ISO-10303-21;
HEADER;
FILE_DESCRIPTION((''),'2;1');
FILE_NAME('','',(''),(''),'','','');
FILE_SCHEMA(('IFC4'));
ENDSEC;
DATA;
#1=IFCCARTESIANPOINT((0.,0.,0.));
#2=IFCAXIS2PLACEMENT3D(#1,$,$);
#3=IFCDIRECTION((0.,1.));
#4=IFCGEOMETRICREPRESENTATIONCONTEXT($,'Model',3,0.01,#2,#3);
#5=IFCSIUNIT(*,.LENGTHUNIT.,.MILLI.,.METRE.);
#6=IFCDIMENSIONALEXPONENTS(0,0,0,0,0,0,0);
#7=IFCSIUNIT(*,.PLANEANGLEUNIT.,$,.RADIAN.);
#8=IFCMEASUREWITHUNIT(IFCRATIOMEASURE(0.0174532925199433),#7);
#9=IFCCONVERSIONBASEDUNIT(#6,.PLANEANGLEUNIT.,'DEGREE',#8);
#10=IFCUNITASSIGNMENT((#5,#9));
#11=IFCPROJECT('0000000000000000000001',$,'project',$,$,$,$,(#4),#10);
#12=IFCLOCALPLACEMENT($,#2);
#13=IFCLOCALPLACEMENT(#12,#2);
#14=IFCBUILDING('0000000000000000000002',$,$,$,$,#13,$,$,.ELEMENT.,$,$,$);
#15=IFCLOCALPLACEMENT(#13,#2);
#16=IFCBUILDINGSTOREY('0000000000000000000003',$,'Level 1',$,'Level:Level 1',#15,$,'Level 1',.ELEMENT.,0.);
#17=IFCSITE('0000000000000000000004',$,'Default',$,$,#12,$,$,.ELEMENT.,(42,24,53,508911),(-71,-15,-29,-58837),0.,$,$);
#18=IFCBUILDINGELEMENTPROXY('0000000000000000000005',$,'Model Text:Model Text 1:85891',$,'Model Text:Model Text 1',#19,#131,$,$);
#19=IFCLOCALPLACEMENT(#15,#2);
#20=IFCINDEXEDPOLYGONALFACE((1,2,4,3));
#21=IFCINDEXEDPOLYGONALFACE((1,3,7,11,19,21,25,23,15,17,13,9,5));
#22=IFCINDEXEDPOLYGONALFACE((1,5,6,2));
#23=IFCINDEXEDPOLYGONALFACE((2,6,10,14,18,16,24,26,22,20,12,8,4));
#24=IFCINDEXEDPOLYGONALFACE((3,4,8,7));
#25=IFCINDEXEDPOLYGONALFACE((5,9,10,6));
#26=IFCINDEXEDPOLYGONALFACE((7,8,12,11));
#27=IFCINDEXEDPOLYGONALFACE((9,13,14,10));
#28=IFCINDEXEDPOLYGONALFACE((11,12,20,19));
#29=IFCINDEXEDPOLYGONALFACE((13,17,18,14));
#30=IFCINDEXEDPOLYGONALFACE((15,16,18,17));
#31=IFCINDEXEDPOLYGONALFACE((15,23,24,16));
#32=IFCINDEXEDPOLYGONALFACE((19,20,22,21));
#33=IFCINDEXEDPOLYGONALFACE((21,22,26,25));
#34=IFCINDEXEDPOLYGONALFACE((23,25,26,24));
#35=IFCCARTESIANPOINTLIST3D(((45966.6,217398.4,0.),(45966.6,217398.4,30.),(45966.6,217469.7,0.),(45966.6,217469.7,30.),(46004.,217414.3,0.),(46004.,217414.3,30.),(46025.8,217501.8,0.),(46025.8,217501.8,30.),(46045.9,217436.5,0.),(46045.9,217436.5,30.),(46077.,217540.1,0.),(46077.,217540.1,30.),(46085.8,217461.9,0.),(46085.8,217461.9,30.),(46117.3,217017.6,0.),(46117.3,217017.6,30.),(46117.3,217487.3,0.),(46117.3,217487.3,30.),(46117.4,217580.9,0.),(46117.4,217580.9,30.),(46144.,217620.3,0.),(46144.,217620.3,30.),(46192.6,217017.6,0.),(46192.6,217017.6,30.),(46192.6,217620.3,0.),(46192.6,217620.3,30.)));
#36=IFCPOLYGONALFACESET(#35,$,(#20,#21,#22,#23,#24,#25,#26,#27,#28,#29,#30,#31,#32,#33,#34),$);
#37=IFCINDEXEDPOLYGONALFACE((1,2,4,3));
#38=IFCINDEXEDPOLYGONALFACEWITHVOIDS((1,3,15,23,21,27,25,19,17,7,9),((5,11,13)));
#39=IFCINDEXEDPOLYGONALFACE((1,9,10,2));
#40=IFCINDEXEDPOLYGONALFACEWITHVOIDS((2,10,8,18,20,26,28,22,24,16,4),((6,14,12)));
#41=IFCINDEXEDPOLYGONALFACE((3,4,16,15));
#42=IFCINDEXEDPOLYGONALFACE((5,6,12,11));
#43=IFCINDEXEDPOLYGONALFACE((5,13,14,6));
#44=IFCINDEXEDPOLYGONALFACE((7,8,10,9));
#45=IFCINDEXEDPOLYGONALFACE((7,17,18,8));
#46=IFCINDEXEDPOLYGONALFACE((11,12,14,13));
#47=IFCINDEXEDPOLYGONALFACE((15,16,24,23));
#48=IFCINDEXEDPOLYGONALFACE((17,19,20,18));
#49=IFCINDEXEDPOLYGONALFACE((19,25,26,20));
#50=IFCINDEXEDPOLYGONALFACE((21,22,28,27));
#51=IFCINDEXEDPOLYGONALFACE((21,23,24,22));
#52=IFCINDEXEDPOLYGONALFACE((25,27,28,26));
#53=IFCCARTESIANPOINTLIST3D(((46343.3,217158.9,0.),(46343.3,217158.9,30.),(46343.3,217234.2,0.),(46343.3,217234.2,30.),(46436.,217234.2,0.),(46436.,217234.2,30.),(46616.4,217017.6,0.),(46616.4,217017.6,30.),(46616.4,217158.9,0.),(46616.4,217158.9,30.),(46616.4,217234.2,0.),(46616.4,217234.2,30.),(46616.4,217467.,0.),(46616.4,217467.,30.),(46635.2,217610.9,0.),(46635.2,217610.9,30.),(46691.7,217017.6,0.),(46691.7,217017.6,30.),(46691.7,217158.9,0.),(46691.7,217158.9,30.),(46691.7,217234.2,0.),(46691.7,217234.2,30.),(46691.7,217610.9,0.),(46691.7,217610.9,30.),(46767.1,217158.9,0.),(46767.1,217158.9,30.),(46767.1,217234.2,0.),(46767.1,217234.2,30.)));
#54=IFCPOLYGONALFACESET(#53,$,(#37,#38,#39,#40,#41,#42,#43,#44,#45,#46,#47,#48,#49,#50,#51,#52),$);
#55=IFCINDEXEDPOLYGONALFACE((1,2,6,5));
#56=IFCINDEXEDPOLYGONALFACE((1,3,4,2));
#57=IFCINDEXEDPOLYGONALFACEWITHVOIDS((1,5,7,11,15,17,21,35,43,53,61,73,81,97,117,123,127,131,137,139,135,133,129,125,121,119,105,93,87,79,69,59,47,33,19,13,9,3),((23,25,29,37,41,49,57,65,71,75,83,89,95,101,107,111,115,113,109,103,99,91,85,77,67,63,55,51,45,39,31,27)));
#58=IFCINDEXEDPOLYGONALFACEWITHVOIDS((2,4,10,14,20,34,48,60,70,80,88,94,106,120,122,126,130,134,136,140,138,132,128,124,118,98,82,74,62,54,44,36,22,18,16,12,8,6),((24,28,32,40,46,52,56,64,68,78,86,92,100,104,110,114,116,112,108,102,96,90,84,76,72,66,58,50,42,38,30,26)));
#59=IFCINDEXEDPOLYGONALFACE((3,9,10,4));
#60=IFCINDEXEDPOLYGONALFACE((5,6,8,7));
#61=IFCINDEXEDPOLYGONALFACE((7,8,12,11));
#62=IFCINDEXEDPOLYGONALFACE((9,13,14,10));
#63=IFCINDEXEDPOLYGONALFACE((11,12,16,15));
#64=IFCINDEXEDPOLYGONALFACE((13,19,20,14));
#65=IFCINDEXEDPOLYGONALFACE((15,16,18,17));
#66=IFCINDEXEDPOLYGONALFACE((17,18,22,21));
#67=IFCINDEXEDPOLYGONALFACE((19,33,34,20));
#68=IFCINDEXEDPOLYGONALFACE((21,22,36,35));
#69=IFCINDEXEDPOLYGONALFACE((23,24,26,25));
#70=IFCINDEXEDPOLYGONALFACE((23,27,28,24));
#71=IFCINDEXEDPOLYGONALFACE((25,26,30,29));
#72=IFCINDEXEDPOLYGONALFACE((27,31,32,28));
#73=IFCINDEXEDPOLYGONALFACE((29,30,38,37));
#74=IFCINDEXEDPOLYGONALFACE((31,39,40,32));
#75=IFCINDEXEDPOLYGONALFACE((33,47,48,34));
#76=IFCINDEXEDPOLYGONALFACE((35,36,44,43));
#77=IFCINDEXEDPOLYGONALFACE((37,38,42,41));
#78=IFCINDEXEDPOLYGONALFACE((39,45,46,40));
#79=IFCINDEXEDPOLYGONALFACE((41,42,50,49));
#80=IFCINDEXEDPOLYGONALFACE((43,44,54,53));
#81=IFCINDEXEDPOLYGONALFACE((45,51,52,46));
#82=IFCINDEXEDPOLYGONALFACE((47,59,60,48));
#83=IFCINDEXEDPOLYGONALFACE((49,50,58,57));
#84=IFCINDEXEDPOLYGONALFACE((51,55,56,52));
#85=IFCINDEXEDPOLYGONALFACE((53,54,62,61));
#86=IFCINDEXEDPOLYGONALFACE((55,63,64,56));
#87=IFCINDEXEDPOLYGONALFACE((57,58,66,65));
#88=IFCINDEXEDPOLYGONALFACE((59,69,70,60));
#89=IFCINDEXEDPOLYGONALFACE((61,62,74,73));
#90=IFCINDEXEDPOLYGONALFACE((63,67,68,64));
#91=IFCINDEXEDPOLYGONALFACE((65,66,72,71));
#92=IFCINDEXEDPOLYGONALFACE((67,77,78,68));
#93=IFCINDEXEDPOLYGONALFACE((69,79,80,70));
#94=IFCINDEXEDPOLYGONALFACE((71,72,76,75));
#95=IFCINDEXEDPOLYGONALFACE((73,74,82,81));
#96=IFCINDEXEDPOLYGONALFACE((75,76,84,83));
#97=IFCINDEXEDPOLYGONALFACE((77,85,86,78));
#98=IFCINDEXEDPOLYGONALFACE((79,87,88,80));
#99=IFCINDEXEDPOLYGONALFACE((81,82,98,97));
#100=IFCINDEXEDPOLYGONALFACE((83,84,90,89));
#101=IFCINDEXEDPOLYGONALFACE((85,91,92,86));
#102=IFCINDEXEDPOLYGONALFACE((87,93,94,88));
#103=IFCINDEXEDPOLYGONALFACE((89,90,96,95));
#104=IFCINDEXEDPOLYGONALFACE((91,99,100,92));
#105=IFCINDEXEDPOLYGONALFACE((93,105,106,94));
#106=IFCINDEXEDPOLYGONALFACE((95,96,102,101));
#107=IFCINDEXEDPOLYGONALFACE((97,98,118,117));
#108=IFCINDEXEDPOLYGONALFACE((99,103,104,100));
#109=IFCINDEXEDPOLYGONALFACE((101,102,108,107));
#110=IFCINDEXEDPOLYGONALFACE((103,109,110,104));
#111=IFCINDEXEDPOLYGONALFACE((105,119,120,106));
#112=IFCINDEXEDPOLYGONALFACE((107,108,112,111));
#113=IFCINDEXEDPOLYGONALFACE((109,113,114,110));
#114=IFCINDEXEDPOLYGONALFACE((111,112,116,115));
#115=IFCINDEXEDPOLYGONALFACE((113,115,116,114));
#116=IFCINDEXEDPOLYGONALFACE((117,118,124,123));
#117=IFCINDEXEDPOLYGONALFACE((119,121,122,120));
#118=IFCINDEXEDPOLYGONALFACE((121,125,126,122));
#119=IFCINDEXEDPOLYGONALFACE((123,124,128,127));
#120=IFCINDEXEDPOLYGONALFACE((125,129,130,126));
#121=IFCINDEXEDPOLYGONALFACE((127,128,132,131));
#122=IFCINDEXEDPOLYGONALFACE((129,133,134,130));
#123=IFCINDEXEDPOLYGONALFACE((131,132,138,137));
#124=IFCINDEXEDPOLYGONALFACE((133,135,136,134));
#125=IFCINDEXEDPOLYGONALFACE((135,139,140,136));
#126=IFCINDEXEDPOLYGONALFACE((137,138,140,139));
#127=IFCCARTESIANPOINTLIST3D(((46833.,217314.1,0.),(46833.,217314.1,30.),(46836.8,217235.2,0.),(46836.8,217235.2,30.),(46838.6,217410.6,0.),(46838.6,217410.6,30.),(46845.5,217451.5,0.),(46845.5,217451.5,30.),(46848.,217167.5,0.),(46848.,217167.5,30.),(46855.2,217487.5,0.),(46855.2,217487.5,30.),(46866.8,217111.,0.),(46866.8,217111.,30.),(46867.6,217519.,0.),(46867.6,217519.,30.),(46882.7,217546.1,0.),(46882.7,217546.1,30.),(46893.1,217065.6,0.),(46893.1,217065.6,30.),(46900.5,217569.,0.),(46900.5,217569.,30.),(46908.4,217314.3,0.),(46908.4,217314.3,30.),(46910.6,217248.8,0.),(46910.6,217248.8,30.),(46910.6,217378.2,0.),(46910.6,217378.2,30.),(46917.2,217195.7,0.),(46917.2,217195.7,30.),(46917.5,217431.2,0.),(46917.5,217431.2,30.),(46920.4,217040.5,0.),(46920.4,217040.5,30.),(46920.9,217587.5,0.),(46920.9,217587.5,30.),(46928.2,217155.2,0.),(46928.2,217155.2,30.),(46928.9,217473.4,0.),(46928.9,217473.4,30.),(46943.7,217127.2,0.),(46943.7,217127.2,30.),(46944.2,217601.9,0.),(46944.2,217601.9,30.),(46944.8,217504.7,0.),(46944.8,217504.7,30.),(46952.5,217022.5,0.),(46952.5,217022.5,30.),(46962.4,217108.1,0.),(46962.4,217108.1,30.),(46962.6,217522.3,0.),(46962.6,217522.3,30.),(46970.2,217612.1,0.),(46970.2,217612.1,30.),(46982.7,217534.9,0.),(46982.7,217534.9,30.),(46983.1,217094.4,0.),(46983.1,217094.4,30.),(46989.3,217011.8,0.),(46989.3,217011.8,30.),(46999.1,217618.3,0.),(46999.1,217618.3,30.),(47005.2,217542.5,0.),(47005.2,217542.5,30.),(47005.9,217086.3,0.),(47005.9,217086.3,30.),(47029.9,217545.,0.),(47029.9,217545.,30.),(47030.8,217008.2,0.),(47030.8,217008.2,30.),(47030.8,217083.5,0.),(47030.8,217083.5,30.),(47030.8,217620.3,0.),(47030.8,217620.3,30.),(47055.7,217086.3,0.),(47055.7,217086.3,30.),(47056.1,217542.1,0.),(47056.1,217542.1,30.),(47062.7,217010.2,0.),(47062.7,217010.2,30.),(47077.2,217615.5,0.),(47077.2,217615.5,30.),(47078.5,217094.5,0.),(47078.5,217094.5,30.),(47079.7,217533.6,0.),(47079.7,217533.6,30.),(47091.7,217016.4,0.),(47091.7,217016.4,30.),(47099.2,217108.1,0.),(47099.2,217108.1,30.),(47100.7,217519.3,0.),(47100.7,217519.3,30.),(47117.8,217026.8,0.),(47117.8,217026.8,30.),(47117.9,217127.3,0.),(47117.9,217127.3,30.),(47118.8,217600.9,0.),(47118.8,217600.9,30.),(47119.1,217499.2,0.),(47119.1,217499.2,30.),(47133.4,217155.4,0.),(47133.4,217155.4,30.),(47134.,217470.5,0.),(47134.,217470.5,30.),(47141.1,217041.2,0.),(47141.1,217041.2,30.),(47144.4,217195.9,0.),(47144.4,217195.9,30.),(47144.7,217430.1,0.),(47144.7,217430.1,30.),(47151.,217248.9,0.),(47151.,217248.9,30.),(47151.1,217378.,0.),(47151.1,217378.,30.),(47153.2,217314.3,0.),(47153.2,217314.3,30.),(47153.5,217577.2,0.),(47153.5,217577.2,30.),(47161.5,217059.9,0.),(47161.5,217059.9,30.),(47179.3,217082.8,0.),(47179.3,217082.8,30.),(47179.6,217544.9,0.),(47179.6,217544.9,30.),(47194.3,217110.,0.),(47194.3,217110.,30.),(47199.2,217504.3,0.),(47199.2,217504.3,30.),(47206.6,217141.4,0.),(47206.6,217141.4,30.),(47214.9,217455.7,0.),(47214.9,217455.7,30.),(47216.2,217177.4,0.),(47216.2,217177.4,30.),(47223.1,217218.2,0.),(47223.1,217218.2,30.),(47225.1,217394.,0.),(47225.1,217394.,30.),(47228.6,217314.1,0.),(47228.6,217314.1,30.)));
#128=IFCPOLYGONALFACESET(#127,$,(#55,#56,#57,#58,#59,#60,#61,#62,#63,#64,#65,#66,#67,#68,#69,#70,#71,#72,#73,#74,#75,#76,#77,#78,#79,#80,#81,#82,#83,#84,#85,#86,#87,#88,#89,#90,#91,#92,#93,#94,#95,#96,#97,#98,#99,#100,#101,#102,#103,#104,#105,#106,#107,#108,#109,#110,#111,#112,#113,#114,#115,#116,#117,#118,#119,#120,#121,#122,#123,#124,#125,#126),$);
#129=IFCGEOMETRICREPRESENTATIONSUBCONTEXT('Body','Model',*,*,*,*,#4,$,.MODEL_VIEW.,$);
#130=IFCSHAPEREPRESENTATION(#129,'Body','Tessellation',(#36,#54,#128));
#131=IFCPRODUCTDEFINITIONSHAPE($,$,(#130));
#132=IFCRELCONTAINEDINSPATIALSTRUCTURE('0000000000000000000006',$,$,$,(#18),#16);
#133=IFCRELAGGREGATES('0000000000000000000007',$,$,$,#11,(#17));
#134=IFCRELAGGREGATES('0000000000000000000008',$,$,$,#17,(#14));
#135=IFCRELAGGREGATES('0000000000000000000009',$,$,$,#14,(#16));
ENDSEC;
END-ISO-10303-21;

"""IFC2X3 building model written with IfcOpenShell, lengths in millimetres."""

from ifc_helpers import new_model, entity, si_unit, converted_unit, direction, frame, origin, place, context, subcontext, project, spatial, polyline, outline, extrude, element, save


model = new_model("IFC2X3")

# Units and contexts
model_context = context("Model", 3, precision=0.01, world=origin(), true_north=direction((0.0, 1.0)))
body_context = subcontext(model_context, "Body", "Model", "MODEL_VIEW")
ifc_project = project(units=[si_unit("LENGTHUNIT", "METRE", prefix="MILLI"), converted_unit("PLANEANGLEUNIT", "DEGREE", entity("IfcRatioMeasure", 0.0174532925199433), si_unit("PLANEANGLEUNIT", "RADIAN"), dimensions=[0, 0, 0, 0, 0, 0, 0])], contexts=[model_context])

# Site, building, storey
site_placement = place(None, origin())
site = spatial("IfcSite", under=ifc_project, at=site_placement, Name="Default", CompositionType="ELEMENT", RefLatitude=(42, 24, 53, 508911), RefLongitude=(-71, -15, -29, -58837), RefElevation=0.0)
building_placement = place(site_placement, origin())
building = spatial("IfcBuilding", under=site, at=building_placement, CompositionType="ELEMENT")
storey_placement = place(building_placement, origin())
storey = spatial("IfcBuildingStorey", under=building, at=storey_placement, Name="Level 1", ObjectType="Level:Level 1", LongName="Level 1", CompositionType="ELEMENT", Elevation=0.0)

# Building element proxy
proxy_1_placement = place(storey_placement, origin())
element("IfcBuildingElementProxy", 1, at=proxy_1_placement, inside=storey, Name="Model Text:Model Text 1:85891", ObjectType="Model Text:Model Text 1", context=body_context, shape_type="SweptSolid", body=[
    extrude(outline(polyline([(-410.6, -111.6), (192.1, -111.6), (192.1, -63.1), (152.7, -36.4), (111.9, 4.0), (73.6, 55.2), (41.4, 114.4), (-29.8, 114.4), (-13.9, 77.0), (8.3, 35.1), (33.7, -4.8), (59.1, -36.3), (-410.6, -36.3), (-410.6, -111.6)])), frame((46081.0, 217428.2, 0.0), z_axis=(0.0, 0.0, 1.0), x_axis=(0.0, 1.0, 0.0)), (0.0, 0.0, 1.0), 30.0),
    extrude(outline(polyline([(-6.8, -218.3), (68.5, -218.3), (68.5, -77.1), (143.8, -77.1), (143.8, -1.7), (68.5, -1.7), (68.5, 375.0), (12.0, 375.0), (-280.0, -1.7), (-280.0, -77.1), (-6.8, -77.1), (-6.8, -218.3)]), holes=[polyline([(-6.8, -1.7), (-187.3, -1.7), (-6.8, 231.1), (-6.8, -1.7)])]), frame((46623.3, 217235.9, 0.0)), (0.0, 0.0, 1.0), 30.0),
    extrude(outline(polyline([(-10.6, -198.7), (68.3, -198.7), (136.5, -190.7), (193.9, -174.7), (240.5, -150.6), (266.9, -124.4), (286.3, -93.2), (298.8, -57.0), (304.3, -15.7), (303.8, 16.2), (299.0, 45.5), (289.9, 72.1), (276.6, 96.0), (258.9, 117.3), (236.9, 136.2), (210.4, 152.5), (179.6, 166.3), (144.1, 177.6), (103.7, 186.3), (8.2, 196.4), (-71.8, 196.7), (-134.0, 189.4), (-183.3, 176.1), (-224.7, 158.4), (-258.2, 133.9), (-283.5, 100.3), (-300.1, 59.5), (-307.1, 13.4), (-306.6, -18.4), (-301.8, -47.5), (-292.8, -74.0), (-279.6, -97.9), (-262.0, -119.2), (-240.0, -138.1), (-213.6, -154.5), (-182.8, -168.4), (-147.3, -179.8), (-106.7, -188.6), (-10.6, -198.7)]), holes=[polyline([(-7.2, -123.5), (-71.0, -118.2), (-123.6, -108.8), (-165.2, -95.4), (-195.7, -78.0), (-212.4, -59.4), (-224.1, -38.7), (-230.6, -15.9), (-231.9, 8.9), (-227.8, 35.0), (-218.1, 58.1), (-202.8, 78.4), (-182.0, 95.8), (-152.6, 109.4), (-111.7, 118.1), (-59.4, 122.0), (4.4, 121.1), (69.6, 115.8), (122.2, 106.7), (162.2, 93.7), (189.5, 77.0), (207.7, 57.4), (220.4, 36.0), (227.5, 12.8), (229.1, -12.1), (225.2, -36.8), (215.9, -59.2), (201.3, -79.3), (181.4, -97.1), (152.6, -111.2), (111.6, -120.3), (58.3, -124.4), (-7.2, -123.5)])]), frame((47032.0, 217312.9, 0.0), z_axis=(0.0, 0.0, 1.0), x_axis=(0.047515, -0.998871, 0.0)), (0.0, 0.0, 1.0), 30.0),
])

save(model, "model.ifc")
